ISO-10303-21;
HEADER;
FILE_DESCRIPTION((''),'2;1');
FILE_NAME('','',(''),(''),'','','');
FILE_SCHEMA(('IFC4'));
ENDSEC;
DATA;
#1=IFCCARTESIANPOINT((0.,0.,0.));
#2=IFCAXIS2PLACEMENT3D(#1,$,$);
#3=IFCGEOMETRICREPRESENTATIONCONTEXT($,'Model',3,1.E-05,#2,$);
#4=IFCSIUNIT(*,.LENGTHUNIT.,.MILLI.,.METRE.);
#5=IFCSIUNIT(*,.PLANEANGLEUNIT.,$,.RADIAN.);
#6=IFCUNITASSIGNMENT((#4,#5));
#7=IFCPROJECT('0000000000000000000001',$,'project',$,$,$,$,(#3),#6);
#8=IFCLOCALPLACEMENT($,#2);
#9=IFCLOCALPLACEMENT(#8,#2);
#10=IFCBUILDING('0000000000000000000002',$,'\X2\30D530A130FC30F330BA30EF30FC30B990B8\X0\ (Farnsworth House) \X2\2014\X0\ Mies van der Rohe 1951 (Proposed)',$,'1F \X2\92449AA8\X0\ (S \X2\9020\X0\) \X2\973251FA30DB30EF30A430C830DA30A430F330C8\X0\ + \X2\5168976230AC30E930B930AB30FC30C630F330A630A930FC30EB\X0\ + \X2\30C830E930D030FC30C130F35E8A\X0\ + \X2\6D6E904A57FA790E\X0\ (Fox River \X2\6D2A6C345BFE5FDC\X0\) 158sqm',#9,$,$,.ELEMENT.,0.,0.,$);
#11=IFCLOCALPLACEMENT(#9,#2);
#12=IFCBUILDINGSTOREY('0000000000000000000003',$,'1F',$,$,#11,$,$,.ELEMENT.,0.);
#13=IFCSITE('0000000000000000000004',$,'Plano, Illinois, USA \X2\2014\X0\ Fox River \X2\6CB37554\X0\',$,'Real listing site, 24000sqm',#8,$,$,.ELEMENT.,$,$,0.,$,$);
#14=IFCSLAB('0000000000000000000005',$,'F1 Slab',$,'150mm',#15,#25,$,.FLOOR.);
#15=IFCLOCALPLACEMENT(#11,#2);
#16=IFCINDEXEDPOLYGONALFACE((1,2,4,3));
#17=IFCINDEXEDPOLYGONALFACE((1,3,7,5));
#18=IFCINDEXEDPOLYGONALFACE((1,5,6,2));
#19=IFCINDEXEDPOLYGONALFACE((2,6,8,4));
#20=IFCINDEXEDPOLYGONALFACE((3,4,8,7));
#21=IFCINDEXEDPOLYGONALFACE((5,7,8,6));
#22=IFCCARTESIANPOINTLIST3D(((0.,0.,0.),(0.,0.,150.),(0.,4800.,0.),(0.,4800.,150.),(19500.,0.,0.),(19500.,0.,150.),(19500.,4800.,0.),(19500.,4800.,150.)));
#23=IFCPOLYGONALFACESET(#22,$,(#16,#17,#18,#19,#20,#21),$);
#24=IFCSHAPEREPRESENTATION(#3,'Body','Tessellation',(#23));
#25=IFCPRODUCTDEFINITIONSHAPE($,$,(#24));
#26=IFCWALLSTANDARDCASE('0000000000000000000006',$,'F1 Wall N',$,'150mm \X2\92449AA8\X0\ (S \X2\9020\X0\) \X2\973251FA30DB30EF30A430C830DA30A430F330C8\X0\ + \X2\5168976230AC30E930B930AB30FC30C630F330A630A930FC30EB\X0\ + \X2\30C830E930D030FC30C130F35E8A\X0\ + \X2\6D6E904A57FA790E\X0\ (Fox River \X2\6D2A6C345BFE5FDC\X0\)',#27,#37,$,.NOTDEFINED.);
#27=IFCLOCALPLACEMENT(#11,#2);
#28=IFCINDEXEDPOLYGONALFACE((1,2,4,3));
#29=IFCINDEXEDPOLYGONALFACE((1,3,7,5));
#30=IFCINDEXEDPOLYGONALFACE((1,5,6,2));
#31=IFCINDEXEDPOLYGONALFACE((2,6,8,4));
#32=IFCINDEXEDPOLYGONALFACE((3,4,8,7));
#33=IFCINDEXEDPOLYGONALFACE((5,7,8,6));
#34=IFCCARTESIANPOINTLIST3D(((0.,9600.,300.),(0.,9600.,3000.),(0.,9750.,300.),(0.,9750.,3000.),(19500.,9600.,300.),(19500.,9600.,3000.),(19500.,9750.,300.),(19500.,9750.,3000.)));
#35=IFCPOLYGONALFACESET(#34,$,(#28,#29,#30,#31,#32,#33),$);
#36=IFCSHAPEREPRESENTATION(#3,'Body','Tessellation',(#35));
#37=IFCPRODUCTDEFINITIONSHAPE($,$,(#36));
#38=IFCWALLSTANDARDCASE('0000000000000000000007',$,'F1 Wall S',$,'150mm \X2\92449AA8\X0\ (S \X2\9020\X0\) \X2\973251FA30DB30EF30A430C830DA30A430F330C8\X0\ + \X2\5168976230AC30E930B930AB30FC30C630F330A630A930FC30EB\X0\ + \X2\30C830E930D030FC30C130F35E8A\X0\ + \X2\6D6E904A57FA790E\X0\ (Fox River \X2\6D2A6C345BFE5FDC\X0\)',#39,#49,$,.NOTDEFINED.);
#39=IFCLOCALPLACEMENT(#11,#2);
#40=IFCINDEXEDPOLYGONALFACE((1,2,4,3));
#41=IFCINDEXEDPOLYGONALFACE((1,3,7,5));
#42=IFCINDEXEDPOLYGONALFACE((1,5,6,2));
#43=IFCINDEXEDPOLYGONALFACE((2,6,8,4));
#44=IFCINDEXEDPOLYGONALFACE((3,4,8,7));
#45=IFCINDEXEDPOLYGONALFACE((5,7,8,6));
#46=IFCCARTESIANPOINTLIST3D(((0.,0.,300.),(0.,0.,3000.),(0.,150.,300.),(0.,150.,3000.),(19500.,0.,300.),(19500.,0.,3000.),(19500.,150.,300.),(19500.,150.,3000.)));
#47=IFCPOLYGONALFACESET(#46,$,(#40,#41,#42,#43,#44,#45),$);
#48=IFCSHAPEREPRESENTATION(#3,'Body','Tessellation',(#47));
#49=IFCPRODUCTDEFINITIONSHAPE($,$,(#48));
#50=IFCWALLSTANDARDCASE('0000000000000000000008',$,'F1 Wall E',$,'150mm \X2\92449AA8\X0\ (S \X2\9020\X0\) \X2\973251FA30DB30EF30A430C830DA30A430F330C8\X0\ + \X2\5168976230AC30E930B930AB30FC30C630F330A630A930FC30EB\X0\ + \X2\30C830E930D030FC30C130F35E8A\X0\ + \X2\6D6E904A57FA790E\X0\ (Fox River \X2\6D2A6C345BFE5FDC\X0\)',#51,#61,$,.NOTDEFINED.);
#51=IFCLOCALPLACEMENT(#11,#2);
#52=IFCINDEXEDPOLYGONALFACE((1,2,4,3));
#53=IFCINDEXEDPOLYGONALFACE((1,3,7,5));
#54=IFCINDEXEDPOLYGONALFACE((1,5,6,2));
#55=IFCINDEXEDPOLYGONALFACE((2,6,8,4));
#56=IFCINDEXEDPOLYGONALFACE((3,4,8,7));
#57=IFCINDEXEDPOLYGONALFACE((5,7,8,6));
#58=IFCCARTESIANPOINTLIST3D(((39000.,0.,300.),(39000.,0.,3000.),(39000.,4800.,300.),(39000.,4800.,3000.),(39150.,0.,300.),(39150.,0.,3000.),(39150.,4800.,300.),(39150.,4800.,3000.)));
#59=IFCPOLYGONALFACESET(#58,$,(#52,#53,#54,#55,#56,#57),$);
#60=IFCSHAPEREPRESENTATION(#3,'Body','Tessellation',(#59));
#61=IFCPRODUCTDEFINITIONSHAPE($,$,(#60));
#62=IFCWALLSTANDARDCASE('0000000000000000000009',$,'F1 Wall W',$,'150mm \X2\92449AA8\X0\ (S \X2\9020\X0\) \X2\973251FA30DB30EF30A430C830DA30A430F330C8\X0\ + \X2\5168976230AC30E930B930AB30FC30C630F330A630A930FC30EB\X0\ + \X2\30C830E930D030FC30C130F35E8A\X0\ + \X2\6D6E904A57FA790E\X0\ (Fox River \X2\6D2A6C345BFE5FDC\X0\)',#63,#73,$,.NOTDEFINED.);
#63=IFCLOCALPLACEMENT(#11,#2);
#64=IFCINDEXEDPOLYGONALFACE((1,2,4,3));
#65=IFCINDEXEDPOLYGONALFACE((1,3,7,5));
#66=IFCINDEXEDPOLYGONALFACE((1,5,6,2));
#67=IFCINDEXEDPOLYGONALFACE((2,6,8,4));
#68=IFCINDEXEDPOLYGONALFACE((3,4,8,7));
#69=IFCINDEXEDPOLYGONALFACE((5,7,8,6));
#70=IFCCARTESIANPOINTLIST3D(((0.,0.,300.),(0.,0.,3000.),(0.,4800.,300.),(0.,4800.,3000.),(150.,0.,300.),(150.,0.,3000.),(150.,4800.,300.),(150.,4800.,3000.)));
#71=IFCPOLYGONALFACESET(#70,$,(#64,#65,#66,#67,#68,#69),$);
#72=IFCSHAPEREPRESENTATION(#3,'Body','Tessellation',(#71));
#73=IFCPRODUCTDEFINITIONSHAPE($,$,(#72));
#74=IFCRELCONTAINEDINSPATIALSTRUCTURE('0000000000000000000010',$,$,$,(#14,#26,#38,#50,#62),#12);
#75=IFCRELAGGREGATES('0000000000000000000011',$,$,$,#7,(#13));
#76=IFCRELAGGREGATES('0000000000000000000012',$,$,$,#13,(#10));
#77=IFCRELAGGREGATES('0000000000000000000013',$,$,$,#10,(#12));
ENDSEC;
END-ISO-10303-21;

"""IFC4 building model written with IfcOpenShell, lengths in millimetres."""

from ifc_helpers import new_model, si_unit, frame, frame_2d, origin, place, context, project, spatial, rectangle, extrude, element, save


model = new_model("IFC4")

# Units and contexts
model_context = context("Model", 3, precision=1e-05, world=origin())
ifc_project = project(units=[si_unit("LENGTHUNIT", "METRE", prefix="MILLI"), si_unit("PLANEANGLEUNIT", "RADIAN")], contexts=[model_context])

# Site, building, storey
site_placement = place(None, origin())
site = spatial("IfcSite", under=ifc_project, at=site_placement, Name="Plano, Illinois, USA — Fox River 河畔", ObjectType="Real listing site, 24000sqm", CompositionType="ELEMENT", RefElevation=0.0)
building_placement = place(site_placement, origin())
building = spatial("IfcBuilding", under=site, at=building_placement, Name="ファーンズワース邸 (Farnsworth House) — Mies van der Rohe 1951 (Proposed)", ObjectType="1F 鉄骨 (S 造) 露出ホワイトペイント + 全面ガラスカーテンウォール + トラバーチン床 + 浮遊基礎 (Fox River 洪水対応) 158sqm", CompositionType="ELEMENT", ElevationOfRefHeight=0.0, ElevationOfTerrain=0.0)
storey_placement = place(building_placement, origin())
storey = spatial("IfcBuildingStorey", under=building, at=storey_placement, Name="1F", CompositionType="ELEMENT", Elevation=0.0)

# Slab
slab_placement = place(storey_placement, origin())
element("IfcSlab", 1, at=slab_placement, inside=storey, Name="F1 Slab", ObjectType="150mm", PredefinedType="FLOOR", context=model_context, shape_type="SweptSolid", body=[
    extrude(rectangle(XDim=19500.0, YDim=4800.0, at=frame_2d((9750.0, 2400.0))), origin(), (0.0, 0.0, 1.0), 150.0),
])

# Walls
wall_1_placement = place(storey_placement, frame((0.0, 4800.0, 150.0)))
element("IfcWallStandardCase", 2, at=wall_1_placement, inside=storey, Name="F1 Wall N", ObjectType="150mm 鉄骨 (S 造) 露出ホワイトペイント + 全面ガラスカーテンウォール + トラバーチン床 + 浮遊基礎 (Fox River 洪水対応)", PredefinedType="NOTDEFINED", context=model_context, shape_type="SweptSolid", body=[
    extrude(rectangle(XDim=19500.0, YDim=150.0, at=frame_2d((9750.0, 75.0))), frame((0.0, 4800.0, 150.0)), (0.0, 0.0, 1.0), 2700.0),
])
wall_2_placement = place(storey_placement, frame((0.0, 0.0, 150.0)))
element("IfcWallStandardCase", 3, at=wall_2_placement, inside=storey, Name="F1 Wall S", ObjectType="150mm 鉄骨 (S 造) 露出ホワイトペイント + 全面ガラスカーテンウォール + トラバーチン床 + 浮遊基礎 (Fox River 洪水対応)", PredefinedType="NOTDEFINED", context=model_context, shape_type="SweptSolid", body=[
    extrude(rectangle(XDim=19500.0, YDim=150.0, at=frame_2d((9750.0, 75.0))), frame((0.0, 0.0, 150.0)), (0.0, 0.0, 1.0), 2700.0),
])
wall_3_placement = place(storey_placement, frame((19500.0, 0.0, 150.0)))
element("IfcWallStandardCase", 4, at=wall_3_placement, inside=storey, Name="F1 Wall E", ObjectType="150mm 鉄骨 (S 造) 露出ホワイトペイント + 全面ガラスカーテンウォール + トラバーチン床 + 浮遊基礎 (Fox River 洪水対応)", PredefinedType="NOTDEFINED", context=model_context, shape_type="SweptSolid", body=[
    extrude(rectangle(XDim=150.0, YDim=4800.0, at=frame_2d((75.0, 2400.0))), frame((19500.0, 0.0, 150.0)), (0.0, 0.0, 1.0), 2700.0),
])
wall_4_placement = place(storey_placement, frame((0.0, 0.0, 150.0)))
element("IfcWallStandardCase", 5, at=wall_4_placement, inside=storey, Name="F1 Wall W", ObjectType="150mm 鉄骨 (S 造) 露出ホワイトペイント + 全面ガラスカーテンウォール + トラバーチン床 + 浮遊基礎 (Fox River 洪水対応)", PredefinedType="NOTDEFINED", context=model_context, shape_type="SweptSolid", body=[
    extrude(rectangle(XDim=150.0, YDim=4800.0, at=frame_2d((75.0, 2400.0))), frame((0.0, 0.0, 150.0)), (0.0, 0.0, 1.0), 2700.0),
])

save(model, "model.ifc")
